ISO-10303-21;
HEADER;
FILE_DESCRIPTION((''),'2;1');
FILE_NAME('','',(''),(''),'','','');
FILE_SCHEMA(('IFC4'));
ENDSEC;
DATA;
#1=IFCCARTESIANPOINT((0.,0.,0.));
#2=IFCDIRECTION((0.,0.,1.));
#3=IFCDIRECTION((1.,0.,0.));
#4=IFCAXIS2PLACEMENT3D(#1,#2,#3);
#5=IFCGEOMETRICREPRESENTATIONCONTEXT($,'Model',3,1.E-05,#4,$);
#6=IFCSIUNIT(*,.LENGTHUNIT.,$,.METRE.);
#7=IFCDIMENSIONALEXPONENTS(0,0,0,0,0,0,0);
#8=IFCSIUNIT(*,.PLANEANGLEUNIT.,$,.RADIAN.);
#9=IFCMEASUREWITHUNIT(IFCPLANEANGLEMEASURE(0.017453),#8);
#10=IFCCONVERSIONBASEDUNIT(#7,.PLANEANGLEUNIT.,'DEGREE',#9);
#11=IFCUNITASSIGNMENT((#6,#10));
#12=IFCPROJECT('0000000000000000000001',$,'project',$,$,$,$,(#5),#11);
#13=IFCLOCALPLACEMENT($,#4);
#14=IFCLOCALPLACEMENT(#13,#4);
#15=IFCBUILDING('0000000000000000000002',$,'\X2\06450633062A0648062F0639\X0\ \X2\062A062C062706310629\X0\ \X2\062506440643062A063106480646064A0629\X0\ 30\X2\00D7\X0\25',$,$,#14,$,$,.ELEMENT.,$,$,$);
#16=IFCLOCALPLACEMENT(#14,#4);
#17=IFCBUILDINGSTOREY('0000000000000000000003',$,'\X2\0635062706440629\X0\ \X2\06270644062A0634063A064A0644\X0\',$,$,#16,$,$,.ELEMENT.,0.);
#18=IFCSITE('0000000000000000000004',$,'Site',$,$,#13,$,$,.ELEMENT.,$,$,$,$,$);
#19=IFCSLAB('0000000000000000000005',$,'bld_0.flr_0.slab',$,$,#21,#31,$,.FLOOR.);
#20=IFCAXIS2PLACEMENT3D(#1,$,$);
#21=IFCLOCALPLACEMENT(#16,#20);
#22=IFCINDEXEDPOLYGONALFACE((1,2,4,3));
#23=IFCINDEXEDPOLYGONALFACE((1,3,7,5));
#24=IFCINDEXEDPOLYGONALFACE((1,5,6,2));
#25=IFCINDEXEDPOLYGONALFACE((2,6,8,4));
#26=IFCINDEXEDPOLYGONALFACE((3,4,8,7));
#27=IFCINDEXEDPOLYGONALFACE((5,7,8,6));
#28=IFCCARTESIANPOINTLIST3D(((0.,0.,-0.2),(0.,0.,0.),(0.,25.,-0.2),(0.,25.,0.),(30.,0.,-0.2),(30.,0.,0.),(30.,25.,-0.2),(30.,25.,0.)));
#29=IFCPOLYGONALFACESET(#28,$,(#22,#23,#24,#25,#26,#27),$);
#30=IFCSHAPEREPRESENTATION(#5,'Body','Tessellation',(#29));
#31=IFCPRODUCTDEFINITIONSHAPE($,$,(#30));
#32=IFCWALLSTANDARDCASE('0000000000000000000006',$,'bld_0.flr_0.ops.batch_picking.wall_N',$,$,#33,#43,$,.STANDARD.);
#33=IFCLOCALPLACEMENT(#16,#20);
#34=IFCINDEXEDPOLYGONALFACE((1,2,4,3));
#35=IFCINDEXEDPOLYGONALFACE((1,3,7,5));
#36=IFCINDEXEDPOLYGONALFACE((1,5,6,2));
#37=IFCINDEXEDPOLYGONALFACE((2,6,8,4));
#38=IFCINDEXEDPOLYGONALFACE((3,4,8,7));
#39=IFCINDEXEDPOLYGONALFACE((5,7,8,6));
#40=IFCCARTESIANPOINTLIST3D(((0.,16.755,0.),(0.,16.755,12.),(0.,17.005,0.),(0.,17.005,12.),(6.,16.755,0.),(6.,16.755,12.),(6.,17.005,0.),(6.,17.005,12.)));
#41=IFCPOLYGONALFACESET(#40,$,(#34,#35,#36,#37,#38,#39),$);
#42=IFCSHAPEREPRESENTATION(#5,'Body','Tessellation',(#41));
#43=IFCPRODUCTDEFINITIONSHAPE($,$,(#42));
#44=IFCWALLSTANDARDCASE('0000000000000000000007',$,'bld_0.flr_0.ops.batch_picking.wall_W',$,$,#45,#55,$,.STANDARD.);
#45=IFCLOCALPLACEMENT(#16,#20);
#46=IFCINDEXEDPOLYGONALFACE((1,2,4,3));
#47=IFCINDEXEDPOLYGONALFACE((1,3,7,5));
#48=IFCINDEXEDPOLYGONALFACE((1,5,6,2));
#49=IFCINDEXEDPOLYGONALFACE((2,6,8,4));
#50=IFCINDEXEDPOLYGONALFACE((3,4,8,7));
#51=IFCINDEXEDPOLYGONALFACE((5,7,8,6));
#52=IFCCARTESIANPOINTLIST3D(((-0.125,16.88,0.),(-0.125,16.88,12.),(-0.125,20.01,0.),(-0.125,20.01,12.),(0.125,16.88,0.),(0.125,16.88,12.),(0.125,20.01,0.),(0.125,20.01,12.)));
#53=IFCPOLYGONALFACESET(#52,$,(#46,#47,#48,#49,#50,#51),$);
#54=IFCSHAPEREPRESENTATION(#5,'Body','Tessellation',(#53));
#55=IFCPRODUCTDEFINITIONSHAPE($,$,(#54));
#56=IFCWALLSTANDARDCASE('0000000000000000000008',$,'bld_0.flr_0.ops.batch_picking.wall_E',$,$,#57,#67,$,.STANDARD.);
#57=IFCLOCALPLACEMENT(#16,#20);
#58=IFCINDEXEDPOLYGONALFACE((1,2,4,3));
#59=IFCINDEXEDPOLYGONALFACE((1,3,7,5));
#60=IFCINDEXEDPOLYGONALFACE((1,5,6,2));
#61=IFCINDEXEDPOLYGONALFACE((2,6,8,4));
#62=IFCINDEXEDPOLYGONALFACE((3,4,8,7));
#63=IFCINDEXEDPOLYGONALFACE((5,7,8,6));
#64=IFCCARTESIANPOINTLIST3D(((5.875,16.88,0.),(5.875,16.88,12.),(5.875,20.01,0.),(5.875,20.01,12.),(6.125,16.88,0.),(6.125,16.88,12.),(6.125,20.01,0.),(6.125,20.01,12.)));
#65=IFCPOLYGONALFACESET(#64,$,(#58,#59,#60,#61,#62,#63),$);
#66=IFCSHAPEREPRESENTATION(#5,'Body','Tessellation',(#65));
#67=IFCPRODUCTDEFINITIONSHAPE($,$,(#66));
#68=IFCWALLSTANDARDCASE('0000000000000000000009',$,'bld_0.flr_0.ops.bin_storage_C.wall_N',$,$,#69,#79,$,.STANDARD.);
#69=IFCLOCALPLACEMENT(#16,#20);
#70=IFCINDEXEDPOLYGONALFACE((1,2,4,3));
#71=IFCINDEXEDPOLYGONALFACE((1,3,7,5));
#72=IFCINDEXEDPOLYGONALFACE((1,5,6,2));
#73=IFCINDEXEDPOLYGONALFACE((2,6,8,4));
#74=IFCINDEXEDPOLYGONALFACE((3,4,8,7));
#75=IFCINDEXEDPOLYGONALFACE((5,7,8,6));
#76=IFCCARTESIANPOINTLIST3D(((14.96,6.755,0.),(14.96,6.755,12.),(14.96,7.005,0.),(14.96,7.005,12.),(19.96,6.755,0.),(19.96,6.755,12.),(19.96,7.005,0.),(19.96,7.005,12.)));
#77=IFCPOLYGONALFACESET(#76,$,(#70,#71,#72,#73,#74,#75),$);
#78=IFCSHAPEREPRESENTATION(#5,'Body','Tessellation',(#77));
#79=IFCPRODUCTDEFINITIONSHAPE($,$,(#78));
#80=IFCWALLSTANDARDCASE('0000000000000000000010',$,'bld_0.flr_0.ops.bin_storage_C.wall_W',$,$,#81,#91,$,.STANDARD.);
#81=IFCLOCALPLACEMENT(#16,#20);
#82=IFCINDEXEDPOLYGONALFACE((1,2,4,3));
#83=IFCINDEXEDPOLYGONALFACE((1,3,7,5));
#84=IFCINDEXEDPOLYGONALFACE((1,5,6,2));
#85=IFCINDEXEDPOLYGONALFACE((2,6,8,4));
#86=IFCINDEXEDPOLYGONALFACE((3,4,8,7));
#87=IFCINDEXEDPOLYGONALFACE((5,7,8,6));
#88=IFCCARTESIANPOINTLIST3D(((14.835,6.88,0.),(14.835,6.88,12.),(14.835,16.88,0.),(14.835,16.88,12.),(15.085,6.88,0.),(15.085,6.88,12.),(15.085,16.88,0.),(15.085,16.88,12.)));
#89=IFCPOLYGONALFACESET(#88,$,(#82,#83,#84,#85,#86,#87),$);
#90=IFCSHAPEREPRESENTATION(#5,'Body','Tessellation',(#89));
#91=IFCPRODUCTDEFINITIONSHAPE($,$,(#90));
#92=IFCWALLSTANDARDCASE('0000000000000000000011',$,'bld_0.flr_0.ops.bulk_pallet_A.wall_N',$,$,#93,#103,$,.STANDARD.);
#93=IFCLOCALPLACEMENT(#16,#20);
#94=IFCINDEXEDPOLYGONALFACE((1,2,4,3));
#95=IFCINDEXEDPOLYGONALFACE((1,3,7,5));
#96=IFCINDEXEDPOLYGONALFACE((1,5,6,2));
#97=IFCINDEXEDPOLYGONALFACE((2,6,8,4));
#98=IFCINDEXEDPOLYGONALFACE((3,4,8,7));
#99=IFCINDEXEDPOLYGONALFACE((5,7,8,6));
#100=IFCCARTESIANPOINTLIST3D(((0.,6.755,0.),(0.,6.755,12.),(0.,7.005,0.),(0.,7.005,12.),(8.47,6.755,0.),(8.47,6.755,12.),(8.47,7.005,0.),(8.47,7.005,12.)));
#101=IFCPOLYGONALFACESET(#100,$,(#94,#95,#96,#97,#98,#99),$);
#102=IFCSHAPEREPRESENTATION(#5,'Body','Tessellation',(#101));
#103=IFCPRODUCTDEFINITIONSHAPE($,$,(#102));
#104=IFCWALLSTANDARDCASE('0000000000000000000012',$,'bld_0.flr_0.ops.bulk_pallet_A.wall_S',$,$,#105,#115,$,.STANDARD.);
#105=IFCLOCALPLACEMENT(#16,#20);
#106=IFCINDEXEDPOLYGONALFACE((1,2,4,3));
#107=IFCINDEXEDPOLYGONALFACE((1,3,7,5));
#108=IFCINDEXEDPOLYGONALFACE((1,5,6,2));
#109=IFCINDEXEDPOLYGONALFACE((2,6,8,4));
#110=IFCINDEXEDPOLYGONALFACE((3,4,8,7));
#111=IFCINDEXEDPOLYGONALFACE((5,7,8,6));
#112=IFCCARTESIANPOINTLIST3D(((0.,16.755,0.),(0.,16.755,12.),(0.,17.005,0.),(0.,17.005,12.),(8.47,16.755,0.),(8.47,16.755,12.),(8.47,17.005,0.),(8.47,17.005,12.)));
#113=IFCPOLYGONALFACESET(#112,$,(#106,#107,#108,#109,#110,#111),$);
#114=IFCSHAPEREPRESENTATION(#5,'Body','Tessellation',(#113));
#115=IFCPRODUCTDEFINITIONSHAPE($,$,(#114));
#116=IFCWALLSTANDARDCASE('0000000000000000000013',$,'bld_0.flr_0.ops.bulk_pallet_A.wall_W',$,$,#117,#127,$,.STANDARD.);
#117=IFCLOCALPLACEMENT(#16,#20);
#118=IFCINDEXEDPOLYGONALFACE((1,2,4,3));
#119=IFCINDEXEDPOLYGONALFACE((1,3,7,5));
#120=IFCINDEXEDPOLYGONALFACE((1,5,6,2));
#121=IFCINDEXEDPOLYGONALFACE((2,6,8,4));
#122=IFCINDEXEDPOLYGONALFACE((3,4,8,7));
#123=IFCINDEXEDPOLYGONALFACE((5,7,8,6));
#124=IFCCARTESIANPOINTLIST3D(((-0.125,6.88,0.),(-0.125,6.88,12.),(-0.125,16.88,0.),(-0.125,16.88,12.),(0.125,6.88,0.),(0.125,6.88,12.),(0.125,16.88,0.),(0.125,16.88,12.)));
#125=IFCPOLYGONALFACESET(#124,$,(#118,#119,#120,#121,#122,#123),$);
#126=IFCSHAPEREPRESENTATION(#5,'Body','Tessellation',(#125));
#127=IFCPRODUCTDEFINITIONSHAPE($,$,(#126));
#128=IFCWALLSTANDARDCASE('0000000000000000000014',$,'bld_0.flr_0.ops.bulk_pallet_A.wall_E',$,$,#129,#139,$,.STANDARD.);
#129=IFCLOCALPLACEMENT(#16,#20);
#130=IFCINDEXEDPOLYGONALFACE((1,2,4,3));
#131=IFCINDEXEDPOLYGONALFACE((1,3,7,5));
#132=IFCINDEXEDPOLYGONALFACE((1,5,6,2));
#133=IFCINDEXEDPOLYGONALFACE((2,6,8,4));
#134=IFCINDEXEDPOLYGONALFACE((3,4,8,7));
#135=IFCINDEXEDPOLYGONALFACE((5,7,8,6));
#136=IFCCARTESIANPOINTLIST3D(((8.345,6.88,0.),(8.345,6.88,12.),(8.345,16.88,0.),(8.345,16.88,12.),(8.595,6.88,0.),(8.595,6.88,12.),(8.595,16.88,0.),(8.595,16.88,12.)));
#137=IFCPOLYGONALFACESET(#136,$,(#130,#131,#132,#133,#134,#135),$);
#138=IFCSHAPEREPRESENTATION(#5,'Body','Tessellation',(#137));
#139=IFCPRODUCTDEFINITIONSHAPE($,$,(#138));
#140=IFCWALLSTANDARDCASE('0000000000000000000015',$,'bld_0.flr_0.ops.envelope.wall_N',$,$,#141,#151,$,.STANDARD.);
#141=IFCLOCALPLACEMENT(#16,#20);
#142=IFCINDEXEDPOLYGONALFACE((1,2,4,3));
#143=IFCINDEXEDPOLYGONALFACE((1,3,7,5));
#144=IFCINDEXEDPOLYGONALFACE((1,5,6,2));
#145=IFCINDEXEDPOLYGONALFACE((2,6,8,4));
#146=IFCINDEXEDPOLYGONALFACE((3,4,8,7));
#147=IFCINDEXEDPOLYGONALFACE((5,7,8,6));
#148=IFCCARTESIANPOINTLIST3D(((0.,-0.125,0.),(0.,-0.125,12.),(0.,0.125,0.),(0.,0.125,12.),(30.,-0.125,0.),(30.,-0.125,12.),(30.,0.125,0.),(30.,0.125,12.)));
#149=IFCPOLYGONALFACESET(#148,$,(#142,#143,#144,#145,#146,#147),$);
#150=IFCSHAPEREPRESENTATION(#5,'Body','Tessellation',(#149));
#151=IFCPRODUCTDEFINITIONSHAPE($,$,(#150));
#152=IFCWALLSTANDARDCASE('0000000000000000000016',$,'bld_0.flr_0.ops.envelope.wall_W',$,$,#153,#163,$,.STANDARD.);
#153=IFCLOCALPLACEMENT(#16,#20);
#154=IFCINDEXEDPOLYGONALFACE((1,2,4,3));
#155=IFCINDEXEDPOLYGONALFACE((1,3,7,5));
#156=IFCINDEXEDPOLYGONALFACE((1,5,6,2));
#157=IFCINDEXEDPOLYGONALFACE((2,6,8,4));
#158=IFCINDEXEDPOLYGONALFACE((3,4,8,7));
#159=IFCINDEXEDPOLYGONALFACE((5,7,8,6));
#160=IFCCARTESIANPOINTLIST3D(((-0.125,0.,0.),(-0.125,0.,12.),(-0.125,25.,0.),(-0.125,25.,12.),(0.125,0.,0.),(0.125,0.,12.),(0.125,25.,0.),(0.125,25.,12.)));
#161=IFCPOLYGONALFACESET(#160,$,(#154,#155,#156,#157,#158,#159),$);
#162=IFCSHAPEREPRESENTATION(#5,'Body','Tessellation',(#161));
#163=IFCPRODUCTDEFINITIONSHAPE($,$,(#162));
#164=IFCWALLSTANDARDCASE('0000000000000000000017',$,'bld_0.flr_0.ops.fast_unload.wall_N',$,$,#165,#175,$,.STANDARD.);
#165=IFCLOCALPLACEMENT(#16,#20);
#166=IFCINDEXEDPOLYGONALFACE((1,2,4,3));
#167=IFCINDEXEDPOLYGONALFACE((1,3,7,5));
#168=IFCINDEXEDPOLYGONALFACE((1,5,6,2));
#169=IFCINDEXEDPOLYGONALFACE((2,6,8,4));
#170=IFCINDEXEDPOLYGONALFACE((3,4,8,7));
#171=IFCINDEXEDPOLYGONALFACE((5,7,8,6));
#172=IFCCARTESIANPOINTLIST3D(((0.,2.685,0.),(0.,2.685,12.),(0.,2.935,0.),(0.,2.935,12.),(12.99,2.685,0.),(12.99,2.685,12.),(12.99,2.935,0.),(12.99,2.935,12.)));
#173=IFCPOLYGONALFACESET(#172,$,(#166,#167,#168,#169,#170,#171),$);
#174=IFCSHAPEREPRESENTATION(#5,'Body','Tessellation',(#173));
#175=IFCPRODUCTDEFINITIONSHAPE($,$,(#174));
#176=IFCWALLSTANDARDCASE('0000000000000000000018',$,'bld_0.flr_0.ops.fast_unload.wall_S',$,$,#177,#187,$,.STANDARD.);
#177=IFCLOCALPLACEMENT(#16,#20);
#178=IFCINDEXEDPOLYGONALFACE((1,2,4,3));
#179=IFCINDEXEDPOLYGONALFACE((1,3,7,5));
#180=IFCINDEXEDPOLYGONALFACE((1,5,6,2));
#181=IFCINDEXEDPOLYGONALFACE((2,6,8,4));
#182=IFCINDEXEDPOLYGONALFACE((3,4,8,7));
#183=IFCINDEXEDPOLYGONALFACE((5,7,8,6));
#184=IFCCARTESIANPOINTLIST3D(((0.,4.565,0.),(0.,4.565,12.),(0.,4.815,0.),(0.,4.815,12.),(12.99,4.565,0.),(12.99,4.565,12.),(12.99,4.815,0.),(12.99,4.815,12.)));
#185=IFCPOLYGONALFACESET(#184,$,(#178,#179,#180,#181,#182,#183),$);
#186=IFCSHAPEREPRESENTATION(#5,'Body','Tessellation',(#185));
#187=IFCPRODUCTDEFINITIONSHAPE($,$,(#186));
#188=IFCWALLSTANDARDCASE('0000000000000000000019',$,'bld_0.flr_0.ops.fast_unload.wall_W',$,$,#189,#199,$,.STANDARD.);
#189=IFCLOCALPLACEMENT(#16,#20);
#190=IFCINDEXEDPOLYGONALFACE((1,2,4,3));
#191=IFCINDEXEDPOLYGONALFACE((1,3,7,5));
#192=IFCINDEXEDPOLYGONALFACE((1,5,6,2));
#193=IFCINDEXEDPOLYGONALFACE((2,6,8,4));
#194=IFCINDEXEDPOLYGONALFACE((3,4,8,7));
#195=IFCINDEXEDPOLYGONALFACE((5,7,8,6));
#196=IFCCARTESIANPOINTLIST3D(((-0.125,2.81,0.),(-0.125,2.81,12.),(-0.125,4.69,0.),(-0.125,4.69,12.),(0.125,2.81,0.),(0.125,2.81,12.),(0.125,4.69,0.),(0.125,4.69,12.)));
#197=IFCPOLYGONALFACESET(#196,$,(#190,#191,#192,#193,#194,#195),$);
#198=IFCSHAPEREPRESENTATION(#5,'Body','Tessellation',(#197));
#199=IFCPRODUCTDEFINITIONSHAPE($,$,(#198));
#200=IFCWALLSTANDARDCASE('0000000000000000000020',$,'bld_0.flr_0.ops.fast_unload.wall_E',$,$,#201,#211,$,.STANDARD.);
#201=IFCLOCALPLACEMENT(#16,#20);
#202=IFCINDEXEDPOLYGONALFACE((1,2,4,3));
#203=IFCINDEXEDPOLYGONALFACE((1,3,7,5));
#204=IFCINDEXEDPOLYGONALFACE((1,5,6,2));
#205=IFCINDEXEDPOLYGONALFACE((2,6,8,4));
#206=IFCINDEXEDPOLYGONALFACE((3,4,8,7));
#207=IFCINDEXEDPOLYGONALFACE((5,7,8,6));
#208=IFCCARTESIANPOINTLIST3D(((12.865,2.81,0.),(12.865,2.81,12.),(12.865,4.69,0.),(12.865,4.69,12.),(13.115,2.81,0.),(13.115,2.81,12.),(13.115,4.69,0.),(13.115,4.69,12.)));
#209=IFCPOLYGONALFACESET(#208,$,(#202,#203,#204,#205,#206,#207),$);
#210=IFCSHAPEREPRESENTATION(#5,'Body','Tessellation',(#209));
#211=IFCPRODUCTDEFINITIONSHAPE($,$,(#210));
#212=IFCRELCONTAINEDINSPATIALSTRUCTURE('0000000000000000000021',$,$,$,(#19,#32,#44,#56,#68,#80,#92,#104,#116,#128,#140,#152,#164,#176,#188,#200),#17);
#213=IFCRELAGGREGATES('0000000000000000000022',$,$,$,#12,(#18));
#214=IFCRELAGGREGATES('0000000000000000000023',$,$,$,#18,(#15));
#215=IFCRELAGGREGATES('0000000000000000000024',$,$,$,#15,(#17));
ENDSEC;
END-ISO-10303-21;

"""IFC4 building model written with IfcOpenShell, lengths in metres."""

from ifc_helpers import new_model, entity, si_unit, converted_unit, frame, frame_2d, origin_with_axes, place, context, project, spatial, rectangle, extrude, element, save


model = new_model("IFC4")

# Units and contexts
model_context = context("Model", 3, precision=1e-05, world=origin_with_axes())
ifc_project = project(units=[si_unit("LENGTHUNIT", "METRE"), converted_unit("PLANEANGLEUNIT", "DEGREE", entity("IfcPlaneAngleMeasure", 0.017453), si_unit("PLANEANGLEUNIT", "RADIAN"), dimensions=[0, 0, 0, 0, 0, 0, 0])], contexts=[model_context])

# Site, building, storey
site_placement = place(None, origin_with_axes())
site = spatial("IfcSite", under=ifc_project, at=site_placement, Name="Site", CompositionType="ELEMENT")
building_placement = place(site_placement, origin_with_axes())
building = spatial("IfcBuilding", under=site, at=building_placement, Name="مستودع تجارة إلكترونية 30×25", CompositionType="ELEMENT")
storey_placement = place(building_placement, origin_with_axes())
storey = spatial("IfcBuildingStorey", under=building, at=storey_placement, Name="صالة التشغيل", CompositionType="ELEMENT", Elevation=0.0)

# Slab
slab_placement = place(storey_placement, origin_with_axes())
element("IfcSlab", 1, at=slab_placement, inside=storey, Name="bld_0.flr_0.slab", PredefinedType="FLOOR", context=model_context, shape_type="SweptSolid", body=[
    extrude(rectangle(XDim=30.0, YDim=25.0, at=frame_2d((15.0, 12.5), x_axis=(1.0, 0.0))), frame((0.0, 0.0, -0.2), z_axis=(0.0, 0.0, 1.0), x_axis=(1.0, 0.0, 0.0)), (0.0, 0.0, 1.0), 0.2),
])

# Walls
wall_1_placement = place(storey_placement, frame((0.0, 16.88, 0.0), z_axis=(0.0, 0.0, 1.0), x_axis=(1.0, 0.0, 0.0)))
element("IfcWallStandardCase", 2, at=wall_1_placement, inside=storey, Name="bld_0.flr_0.ops.batch_picking.wall_N", PredefinedType="STANDARD", context=model_context, shape_type="SweptSolid", body=[
    extrude(rectangle(XDim=6.0, YDim=0.25, at=frame_2d((3.0, 0.0), x_axis=(1.0, 0.0))), origin_with_axes(), (0.0, 0.0, 1.0), 12.0),
])
for number, where, z_axis, x_axis, name in (
    (3, (0.0, 16.88, 0.0), (0.0, 0.0, 1.0), (0.0, 1.0, 0.0), "bld_0.flr_0.ops.batch_picking.wall_W"),
    (4, (6.0, 16.88, 0.0), (0.0, 0.0, 1.0), (0.0, 1.0, 0.0), "bld_0.flr_0.ops.batch_picking.wall_E"),
):
    element("IfcWallStandardCase", number, at=place(storey_placement, frame(where, z_axis=z_axis, x_axis=x_axis)), inside=storey, Name=name, PredefinedType="STANDARD", context=model_context, shape_type="SweptSolid", body=[
        extrude(rectangle(XDim=3.13, YDim=0.25, at=frame_2d((1.565, 0.0), x_axis=(1.0, 0.0))), origin_with_axes(), (0.0, 0.0, 1.0), 12.0),
    ])
wall_2_placement = place(storey_placement, frame((14.96, 6.88, 0.0), z_axis=(0.0, 0.0, 1.0), x_axis=(1.0, 0.0, 0.0)))
element("IfcWallStandardCase", 5, at=wall_2_placement, inside=storey, Name="bld_0.flr_0.ops.bin_storage_C.wall_N", PredefinedType="STANDARD", context=model_context, shape_type="SweptSolid", body=[
    extrude(rectangle(XDim=5.0, YDim=0.25, at=frame_2d((2.5, 0.0), x_axis=(1.0, 0.0))), origin_with_axes(), (0.0, 0.0, 1.0), 12.0),
])
wall_3_placement = place(storey_placement, frame((14.96, 6.88, 0.0), z_axis=(0.0, 0.0, 1.0), x_axis=(0.0, 1.0, 0.0)))
element("IfcWallStandardCase", 6, at=wall_3_placement, inside=storey, Name="bld_0.flr_0.ops.bin_storage_C.wall_W", PredefinedType="STANDARD", context=model_context, shape_type="SweptSolid", body=[
    extrude(rectangle(XDim=10.0, YDim=0.25, at=frame_2d((5.0, 0.0), x_axis=(1.0, 0.0))), origin_with_axes(), (0.0, 0.0, 1.0), 12.0),
])
for number, where, z_axis, x_axis, name in (
    (7, (0.0, 6.88, 0.0), (0.0, 0.0, 1.0), (1.0, 0.0, 0.0), "bld_0.flr_0.ops.bulk_pallet_A.wall_N"),
    (8, (0.0, 16.88, 0.0), (0.0, 0.0, 1.0), (1.0, 0.0, 0.0), "bld_0.flr_0.ops.bulk_pallet_A.wall_S"),
):
    element("IfcWallStandardCase", number, at=place(storey_placement, frame(where, z_axis=z_axis, x_axis=x_axis)), inside=storey, Name=name, PredefinedType="STANDARD", context=model_context, shape_type="SweptSolid", body=[
        extrude(rectangle(XDim=8.47, YDim=0.25, at=frame_2d((4.235, 0.0), x_axis=(1.0, 0.0))), origin_with_axes(), (0.0, 0.0, 1.0), 12.0),
    ])
for number, where, z_axis, x_axis, name in (
    (9, (0.0, 6.88, 0.0), (0.0, 0.0, 1.0), (0.0, 1.0, 0.0), "bld_0.flr_0.ops.bulk_pallet_A.wall_W"),
    (10, (8.47, 6.88, 0.0), (0.0, 0.0, 1.0), (0.0, 1.0, 0.0), "bld_0.flr_0.ops.bulk_pallet_A.wall_E"),
):
    element("IfcWallStandardCase", number, at=place(storey_placement, frame(where, z_axis=z_axis, x_axis=x_axis)), inside=storey, Name=name, PredefinedType="STANDARD", context=model_context, shape_type="SweptSolid", body=[
        extrude(rectangle(XDim=10.0, YDim=0.25, at=frame_2d((5.0, 0.0), x_axis=(1.0, 0.0))), origin_with_axes(), (0.0, 0.0, 1.0), 12.0),
    ])
wall_4_placement = place(storey_placement, origin_with_axes())
element("IfcWallStandardCase", 11, at=wall_4_placement, inside=storey, Name="bld_0.flr_0.ops.envelope.wall_N", PredefinedType="STANDARD", context=model_context, shape_type="SweptSolid", body=[
    extrude(rectangle(XDim=30.0, YDim=0.25, at=frame_2d((15.0, 0.0), x_axis=(1.0, 0.0))), origin_with_axes(), (0.0, 0.0, 1.0), 12.0),
])
wall_5_placement = place(storey_placement, frame((0.0, 0.0, 0.0), z_axis=(0.0, 0.0, 1.0), x_axis=(0.0, 1.0, 0.0)))
element("IfcWallStandardCase", 12, at=wall_5_placement, inside=storey, Name="bld_0.flr_0.ops.envelope.wall_W", PredefinedType="STANDARD", context=model_context, shape_type="SweptSolid", body=[
    extrude(rectangle(XDim=25.0, YDim=0.25, at=frame_2d((12.5, 0.0), x_axis=(1.0, 0.0))), origin_with_axes(), (0.0, 0.0, 1.0), 12.0),
])
for number, where, z_axis, x_axis, name in (
    (13, (0.0, 2.81, 0.0), (0.0, 0.0, 1.0), (1.0, 0.0, 0.0), "bld_0.flr_0.ops.fast_unload.wall_N"),
    (14, (0.0, 4.69, 0.0), (0.0, 0.0, 1.0), (1.0, 0.0, 0.0), "bld_0.flr_0.ops.fast_unload.wall_S"),
):
    element("IfcWallStandardCase", number, at=place(storey_placement, frame(where, z_axis=z_axis, x_axis=x_axis)), inside=storey, Name=name, PredefinedType="STANDARD", context=model_context, shape_type="SweptSolid", body=[
        extrude(rectangle(XDim=12.99, YDim=0.25, at=frame_2d((6.495, 0.0), x_axis=(1.0, 0.0))), origin_with_axes(), (0.0, 0.0, 1.0), 12.0),
    ])
for number, where, z_axis, x_axis, name in (
    (15, (0.0, 2.81, 0.0), (0.0, 0.0, 1.0), (0.0, 1.0, 0.0), "bld_0.flr_0.ops.fast_unload.wall_W"),
    (16, (12.99, 2.81, 0.0), (0.0, 0.0, 1.0), (0.0, 1.0, 0.0), "bld_0.flr_0.ops.fast_unload.wall_E"),
):
    element("IfcWallStandardCase", number, at=place(storey_placement, frame(where, z_axis=z_axis, x_axis=x_axis)), inside=storey, Name=name, PredefinedType="STANDARD", context=model_context, shape_type="SweptSolid", body=[
        extrude(rectangle(XDim=1.88, YDim=0.25, at=frame_2d((0.94, 0.0), x_axis=(1.0, 0.0))), origin_with_axes(), (0.0, 0.0, 1.0), 12.0),
    ])

save(model, "model.ifc")
